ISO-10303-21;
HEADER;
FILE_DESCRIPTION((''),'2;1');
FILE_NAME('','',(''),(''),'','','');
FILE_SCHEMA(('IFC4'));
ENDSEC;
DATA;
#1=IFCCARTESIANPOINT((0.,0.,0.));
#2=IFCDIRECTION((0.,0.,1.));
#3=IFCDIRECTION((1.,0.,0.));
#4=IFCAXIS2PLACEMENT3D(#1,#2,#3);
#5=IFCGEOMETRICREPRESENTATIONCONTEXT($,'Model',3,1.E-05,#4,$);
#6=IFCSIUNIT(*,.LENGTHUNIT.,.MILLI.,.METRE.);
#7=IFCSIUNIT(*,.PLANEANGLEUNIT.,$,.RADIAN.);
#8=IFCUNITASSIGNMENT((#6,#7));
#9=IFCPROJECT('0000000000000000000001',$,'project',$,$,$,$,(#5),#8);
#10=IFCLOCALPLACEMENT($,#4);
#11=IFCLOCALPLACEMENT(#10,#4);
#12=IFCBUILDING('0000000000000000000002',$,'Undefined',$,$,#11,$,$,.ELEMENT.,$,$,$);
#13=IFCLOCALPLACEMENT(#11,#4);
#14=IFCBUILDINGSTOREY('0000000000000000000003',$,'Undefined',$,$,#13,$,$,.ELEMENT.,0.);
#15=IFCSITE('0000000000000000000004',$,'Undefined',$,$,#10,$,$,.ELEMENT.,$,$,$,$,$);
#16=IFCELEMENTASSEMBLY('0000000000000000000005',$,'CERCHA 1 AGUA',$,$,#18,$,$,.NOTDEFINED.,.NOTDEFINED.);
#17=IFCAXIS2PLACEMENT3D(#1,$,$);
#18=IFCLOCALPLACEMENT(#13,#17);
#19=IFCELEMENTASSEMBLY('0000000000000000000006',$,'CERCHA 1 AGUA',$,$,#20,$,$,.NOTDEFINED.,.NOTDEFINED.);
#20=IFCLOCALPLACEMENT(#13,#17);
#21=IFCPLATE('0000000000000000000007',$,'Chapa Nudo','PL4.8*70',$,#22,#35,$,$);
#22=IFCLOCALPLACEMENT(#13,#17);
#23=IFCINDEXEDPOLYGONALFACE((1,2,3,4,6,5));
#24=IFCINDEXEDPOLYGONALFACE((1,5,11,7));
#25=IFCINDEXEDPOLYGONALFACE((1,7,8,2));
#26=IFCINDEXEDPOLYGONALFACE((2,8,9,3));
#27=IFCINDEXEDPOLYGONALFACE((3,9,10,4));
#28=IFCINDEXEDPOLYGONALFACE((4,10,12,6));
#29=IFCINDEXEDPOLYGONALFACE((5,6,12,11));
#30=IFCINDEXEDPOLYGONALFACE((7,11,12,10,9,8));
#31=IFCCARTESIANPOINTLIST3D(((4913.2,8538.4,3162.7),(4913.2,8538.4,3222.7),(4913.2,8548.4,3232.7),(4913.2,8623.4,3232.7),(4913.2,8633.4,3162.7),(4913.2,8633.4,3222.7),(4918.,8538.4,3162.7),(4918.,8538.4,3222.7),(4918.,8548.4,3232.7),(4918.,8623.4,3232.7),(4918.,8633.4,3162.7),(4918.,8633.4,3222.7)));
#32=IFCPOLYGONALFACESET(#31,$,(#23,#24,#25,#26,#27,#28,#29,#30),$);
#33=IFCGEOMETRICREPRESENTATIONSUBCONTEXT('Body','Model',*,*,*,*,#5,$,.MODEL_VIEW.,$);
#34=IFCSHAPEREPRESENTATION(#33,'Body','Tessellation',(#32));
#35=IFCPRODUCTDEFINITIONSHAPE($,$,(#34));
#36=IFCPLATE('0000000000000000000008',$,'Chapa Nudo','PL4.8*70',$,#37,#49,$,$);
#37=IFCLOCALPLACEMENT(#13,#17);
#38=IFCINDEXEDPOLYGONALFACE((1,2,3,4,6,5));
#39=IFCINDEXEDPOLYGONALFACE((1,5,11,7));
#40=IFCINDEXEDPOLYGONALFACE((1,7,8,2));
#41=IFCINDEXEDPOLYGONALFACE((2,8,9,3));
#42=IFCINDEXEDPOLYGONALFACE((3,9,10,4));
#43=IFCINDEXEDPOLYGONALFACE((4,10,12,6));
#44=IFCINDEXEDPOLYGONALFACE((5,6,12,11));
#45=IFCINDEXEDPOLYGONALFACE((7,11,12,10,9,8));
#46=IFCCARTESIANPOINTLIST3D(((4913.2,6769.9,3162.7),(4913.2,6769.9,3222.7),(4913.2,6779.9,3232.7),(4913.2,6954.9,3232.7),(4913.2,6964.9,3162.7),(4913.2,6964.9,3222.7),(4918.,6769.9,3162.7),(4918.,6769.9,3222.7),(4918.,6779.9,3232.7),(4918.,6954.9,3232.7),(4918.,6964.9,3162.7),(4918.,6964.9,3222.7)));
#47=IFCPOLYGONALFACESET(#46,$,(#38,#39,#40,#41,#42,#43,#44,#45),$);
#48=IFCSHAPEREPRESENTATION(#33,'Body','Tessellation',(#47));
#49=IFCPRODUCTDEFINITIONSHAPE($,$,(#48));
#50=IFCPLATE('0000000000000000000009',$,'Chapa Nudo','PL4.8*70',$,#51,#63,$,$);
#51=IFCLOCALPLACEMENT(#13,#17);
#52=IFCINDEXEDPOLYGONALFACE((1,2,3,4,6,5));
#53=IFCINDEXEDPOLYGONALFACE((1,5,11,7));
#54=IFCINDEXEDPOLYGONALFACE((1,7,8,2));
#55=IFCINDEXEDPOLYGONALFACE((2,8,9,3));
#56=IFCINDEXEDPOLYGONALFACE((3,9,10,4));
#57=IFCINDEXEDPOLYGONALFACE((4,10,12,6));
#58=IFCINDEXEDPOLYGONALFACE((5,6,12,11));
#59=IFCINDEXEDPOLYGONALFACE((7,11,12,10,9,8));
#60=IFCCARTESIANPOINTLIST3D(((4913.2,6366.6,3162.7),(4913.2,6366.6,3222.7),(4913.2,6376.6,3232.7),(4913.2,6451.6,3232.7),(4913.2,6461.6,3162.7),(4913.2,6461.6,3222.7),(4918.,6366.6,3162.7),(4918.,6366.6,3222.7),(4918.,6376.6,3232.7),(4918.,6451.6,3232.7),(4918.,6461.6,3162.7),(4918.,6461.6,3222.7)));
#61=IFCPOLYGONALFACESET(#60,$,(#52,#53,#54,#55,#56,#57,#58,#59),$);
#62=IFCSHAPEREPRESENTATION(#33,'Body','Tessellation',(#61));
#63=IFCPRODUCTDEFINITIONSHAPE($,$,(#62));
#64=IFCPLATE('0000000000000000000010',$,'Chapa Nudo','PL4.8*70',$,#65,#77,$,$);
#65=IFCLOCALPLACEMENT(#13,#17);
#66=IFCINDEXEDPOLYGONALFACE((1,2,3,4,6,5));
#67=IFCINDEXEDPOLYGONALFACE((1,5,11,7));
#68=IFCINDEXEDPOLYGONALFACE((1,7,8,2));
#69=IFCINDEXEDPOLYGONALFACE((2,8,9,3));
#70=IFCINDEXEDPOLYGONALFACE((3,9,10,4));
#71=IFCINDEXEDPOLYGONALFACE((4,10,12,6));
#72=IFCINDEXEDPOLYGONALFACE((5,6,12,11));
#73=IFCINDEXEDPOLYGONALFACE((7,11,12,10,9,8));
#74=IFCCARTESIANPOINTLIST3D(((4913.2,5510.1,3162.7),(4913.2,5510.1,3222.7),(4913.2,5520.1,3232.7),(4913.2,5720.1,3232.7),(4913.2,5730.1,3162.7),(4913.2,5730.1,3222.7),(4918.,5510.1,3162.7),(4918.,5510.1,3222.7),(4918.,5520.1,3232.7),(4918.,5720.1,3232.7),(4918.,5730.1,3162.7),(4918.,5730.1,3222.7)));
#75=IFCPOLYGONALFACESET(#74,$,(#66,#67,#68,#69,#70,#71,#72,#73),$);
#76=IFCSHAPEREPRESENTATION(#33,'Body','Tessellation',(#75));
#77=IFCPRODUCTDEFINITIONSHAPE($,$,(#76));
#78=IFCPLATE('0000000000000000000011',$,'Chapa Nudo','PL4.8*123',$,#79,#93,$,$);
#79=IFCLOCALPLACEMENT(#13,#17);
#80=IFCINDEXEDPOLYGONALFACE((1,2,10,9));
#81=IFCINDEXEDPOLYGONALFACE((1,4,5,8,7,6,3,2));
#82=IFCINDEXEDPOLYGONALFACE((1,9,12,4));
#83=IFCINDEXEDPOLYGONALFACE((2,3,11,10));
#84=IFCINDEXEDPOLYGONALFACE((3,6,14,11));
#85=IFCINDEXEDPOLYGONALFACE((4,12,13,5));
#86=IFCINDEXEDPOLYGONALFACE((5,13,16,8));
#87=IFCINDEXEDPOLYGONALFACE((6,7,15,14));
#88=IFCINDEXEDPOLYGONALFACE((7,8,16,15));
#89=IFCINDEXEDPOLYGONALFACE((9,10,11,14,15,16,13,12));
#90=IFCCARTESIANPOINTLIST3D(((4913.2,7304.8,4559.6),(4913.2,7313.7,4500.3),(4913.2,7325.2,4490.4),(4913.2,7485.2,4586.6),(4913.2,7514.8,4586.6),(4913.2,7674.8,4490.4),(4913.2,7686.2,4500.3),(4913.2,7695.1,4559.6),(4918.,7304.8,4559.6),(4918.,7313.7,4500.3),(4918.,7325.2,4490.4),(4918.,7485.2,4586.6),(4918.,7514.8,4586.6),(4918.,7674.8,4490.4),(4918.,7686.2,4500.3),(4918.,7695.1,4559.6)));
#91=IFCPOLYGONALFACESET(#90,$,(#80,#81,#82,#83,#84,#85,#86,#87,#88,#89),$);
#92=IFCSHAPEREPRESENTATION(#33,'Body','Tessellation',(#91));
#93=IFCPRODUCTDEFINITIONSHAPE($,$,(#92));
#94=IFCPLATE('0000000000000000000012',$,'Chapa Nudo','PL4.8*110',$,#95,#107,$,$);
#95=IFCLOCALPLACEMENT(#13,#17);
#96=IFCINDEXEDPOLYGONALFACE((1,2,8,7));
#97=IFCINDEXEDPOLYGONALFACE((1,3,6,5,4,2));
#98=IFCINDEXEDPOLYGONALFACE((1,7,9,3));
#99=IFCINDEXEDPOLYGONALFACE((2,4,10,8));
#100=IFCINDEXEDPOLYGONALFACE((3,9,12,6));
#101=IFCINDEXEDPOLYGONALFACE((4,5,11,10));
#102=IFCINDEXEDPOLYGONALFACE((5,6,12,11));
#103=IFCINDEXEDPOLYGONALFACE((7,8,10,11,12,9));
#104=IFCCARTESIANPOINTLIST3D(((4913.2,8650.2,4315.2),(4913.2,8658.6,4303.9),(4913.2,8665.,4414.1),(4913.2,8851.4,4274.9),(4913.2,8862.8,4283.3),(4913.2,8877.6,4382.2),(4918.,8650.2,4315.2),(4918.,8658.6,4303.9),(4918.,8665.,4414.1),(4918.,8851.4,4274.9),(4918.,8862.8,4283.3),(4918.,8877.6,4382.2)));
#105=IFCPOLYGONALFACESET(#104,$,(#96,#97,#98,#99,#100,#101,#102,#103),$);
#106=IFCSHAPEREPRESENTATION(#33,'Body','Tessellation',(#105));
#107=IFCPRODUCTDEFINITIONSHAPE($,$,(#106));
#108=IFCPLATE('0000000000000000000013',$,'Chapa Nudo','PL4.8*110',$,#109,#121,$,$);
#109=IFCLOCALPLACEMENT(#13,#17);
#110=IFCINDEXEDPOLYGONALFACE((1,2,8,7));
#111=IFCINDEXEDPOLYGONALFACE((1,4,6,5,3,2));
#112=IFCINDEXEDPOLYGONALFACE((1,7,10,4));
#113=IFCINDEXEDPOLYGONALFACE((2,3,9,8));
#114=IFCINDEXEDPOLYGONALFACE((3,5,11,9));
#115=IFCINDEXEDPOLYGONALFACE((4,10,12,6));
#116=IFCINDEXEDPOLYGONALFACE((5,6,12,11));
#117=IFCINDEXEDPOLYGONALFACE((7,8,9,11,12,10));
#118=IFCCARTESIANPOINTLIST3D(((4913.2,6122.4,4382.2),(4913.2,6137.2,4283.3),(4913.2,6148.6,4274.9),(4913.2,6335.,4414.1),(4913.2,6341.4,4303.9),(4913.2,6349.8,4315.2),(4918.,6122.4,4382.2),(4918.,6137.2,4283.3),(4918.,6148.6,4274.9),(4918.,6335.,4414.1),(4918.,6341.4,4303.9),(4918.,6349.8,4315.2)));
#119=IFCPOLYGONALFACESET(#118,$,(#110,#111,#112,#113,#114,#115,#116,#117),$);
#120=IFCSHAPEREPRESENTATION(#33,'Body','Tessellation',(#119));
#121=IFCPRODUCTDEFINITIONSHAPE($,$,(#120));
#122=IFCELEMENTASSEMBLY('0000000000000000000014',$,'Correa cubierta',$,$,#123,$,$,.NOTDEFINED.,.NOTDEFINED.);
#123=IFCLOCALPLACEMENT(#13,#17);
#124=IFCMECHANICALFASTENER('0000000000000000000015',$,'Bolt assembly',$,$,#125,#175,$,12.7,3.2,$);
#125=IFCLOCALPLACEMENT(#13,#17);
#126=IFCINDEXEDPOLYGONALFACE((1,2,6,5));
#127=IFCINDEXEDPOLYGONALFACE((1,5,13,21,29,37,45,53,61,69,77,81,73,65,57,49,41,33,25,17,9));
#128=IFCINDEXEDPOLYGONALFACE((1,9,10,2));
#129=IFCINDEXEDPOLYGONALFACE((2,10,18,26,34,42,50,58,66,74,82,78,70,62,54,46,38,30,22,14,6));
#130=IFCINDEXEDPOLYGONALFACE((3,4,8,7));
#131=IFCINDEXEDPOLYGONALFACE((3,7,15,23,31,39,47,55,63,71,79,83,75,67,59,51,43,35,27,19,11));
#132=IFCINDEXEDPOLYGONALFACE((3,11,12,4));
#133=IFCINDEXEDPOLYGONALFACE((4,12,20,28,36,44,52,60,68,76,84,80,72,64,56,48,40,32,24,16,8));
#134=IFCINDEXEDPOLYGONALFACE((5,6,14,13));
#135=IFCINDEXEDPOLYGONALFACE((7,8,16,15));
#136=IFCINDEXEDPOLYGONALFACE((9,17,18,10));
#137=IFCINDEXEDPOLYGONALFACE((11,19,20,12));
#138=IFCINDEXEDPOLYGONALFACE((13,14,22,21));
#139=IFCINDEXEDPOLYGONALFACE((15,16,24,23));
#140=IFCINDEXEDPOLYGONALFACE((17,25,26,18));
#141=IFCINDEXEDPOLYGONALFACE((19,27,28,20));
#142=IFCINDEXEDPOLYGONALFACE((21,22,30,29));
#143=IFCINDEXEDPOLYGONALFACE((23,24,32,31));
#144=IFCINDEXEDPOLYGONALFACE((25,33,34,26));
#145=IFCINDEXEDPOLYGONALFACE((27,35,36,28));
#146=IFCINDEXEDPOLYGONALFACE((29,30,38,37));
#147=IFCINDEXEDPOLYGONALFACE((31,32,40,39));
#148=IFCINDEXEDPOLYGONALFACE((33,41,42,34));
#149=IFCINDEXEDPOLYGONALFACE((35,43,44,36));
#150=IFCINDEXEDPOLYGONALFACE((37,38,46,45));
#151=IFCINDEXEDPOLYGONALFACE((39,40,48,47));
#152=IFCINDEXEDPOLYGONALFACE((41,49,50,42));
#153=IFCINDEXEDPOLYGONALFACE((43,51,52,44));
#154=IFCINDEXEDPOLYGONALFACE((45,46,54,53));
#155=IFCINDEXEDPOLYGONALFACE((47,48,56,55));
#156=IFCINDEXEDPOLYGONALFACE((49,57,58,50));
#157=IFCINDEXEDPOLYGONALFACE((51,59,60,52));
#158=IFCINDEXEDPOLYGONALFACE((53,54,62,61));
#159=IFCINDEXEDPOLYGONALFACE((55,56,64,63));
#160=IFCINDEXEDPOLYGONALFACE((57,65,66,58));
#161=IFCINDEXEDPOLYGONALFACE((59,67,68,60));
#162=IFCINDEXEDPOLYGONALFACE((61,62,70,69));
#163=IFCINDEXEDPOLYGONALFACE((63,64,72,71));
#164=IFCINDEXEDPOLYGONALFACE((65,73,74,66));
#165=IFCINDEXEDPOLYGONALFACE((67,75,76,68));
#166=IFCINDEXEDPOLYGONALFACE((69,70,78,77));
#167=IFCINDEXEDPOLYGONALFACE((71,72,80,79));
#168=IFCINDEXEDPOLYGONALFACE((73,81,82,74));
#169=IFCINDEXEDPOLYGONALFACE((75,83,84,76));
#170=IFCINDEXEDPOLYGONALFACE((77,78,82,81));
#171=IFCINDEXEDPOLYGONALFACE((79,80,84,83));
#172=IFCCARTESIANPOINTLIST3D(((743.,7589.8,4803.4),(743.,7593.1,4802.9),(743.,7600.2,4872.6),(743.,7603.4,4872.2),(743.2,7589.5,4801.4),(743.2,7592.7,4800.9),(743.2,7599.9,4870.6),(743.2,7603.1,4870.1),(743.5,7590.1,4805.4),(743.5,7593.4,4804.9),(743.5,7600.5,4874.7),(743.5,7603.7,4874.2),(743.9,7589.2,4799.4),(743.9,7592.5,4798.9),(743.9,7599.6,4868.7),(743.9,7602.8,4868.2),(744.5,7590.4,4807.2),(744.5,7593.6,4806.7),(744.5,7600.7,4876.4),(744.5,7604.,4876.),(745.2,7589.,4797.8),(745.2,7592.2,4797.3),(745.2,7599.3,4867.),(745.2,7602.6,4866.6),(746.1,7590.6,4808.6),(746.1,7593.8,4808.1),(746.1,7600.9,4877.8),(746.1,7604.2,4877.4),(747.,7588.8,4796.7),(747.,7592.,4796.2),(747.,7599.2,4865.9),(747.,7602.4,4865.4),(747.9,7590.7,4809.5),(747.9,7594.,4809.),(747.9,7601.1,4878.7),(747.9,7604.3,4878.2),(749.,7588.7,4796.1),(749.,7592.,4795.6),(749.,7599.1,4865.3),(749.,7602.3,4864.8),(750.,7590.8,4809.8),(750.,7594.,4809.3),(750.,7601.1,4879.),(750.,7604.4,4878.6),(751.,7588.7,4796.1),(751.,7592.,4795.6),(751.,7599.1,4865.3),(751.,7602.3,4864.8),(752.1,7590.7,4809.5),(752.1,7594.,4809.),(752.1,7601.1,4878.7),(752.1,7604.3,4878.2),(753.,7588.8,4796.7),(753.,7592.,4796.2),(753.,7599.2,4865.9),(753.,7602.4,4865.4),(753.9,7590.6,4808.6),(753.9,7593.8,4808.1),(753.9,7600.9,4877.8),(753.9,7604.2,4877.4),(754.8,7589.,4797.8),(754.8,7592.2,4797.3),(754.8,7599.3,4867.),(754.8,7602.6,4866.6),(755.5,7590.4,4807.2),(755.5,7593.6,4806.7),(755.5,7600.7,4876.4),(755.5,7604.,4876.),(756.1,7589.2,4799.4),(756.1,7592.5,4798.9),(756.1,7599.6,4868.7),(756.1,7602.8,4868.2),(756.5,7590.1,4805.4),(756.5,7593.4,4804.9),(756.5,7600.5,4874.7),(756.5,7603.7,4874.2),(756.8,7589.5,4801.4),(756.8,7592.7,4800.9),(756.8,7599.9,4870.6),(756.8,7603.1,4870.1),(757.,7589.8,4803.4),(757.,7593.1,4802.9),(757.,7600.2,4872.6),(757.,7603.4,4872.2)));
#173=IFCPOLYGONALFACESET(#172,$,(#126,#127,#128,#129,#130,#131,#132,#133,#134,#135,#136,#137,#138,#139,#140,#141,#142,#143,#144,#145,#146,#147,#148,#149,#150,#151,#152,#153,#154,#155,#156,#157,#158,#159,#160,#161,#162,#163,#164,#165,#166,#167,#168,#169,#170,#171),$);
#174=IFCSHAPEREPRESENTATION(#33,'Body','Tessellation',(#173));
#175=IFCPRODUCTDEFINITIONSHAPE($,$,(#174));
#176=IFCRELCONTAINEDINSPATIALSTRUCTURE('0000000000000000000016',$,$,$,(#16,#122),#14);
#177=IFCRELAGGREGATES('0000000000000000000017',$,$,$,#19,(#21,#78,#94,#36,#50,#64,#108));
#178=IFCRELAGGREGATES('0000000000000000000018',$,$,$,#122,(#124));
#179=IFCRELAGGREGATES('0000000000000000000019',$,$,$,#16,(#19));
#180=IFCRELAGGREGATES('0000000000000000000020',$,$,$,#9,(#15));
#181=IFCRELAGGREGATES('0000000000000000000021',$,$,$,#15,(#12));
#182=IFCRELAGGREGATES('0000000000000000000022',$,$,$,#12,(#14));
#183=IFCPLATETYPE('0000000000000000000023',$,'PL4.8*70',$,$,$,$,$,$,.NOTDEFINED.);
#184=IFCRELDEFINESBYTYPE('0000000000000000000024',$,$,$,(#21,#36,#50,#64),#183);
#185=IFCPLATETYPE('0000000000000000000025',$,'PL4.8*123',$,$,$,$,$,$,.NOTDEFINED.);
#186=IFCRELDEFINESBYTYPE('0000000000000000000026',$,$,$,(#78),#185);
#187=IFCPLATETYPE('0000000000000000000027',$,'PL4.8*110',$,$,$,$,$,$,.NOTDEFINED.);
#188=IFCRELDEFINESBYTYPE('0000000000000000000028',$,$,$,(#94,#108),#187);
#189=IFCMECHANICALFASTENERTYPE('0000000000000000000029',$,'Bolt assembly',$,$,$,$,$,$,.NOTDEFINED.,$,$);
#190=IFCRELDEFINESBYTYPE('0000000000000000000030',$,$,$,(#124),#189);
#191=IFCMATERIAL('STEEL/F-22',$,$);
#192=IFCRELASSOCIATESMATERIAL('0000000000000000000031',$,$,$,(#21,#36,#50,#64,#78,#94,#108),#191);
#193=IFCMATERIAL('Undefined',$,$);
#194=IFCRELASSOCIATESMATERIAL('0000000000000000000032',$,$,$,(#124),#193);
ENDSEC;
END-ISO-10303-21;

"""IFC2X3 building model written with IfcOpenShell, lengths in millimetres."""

from ifc_helpers import new_model, si_unit, frame, origin_with_axes, origin_2d_with_axis, place, context, subcontext, project, spatial, polyline, circle, outline, extrude, source, transform, mapped, material, type_object, element, aggregate, save


model = new_model("IFC2X3")

# Units and contexts
model_context = context("Model", 3, precision=1e-05, world=origin_with_axes())
body_context = subcontext(model_context, "Body", "Model", "MODEL_VIEW")
ifc_project = project(units=[si_unit("LENGTHUNIT", "METRE", prefix="MILLI"), si_unit("PLANEANGLEUNIT", "RADIAN")], contexts=[model_context])

# Site, building, storey
site_placement = place(None, origin_with_axes())
site = spatial("IfcSite", under=ifc_project, at=site_placement, Name="Undefined", CompositionType="ELEMENT")
building_placement = place(site_placement, origin_with_axes())
building = spatial("IfcBuilding", under=site, at=building_placement, Name="Undefined", CompositionType="ELEMENT")
storey_placement = place(building_placement, origin_with_axes())
storey = spatial("IfcBuildingStorey", under=building, at=storey_placement, Name="Undefined", CompositionType="ELEMENT", Elevation=0.0)

# Element assembly
assembly_1_placement = place(storey_placement, origin_with_axes())
assembly_1 = element("IfcElementAssembly", 1, at=assembly_1_placement, inside=storey, Name="CERCHA 1 AGUA", AssemblyPlace="NOTDEFINED", PredefinedType="NOTDEFINED")

# Element assembly, plates
assembly_2_placement = place(assembly_1_placement, origin_with_axes())
assembly_2 = element("IfcElementAssembly", 2, at=assembly_2_placement, Name="CERCHA 1 AGUA", AssemblyPlace="NOTDEFINED", PredefinedType="NOTDEFINED")
ifc_material_1 = material(Name="STEEL/F-22")
plate_type_1 = type_object("IfcPlateType", Name="PL4.8*70", PredefinedType="NOTDEFINED")
plate_1_placement = place(assembly_2_placement, frame((4915.6, 8633.4, 3232.7), z_axis=(-1.0, 0.0, 0.0), x_axis=(0.0, 0.0, -1.0)))
plate_1 = element("IfcPlate", 3, at=plate_1_placement, type_object=plate_type_1, material=ifc_material_1, Name="Chapa Nudo", Description="PL4.8*70", context=body_context, shape_type="SweptSolid", body=[
    extrude(outline(polyline([(0.0, 10.0), (10.0, 0.0), (70.0, 0.0), (70.0, 95.0), (10.0, 95.0), (0.0, 85.0), (0.0, 10.0)])), frame((0.0, 0.0, -2.4), z_axis=(0.0, 0.0, 1.0), x_axis=(1.0, 0.0, 0.0)), (0.0, 0.0, 1.0), 4.8),
])
plate_2_placement = place(assembly_2_placement, frame((4915.6, 6769.9, 3232.7), z_axis=(1.0, 0.0, 0.0), x_axis=(0.0, 0.0, -1.0)))
plate_2 = element("IfcPlate", 4, at=plate_2_placement, type_object=plate_type_1, material=ifc_material_1, Name="Chapa Nudo", Description="PL4.8*70", context=body_context, shape_type="SweptSolid", body=[
    extrude(outline(polyline([(0.0, 10.0), (10.0, 0.0), (70.0, 0.0), (70.0, 195.0), (10.0, 195.0), (0.0, 185.0), (0.0, 10.0)])), frame((0.0, 0.0, -2.4), z_axis=(0.0, 0.0, 1.0), x_axis=(1.0, 0.0, 0.0)), (0.0, 0.0, 1.0), 4.8),
])
plate_3_placement = place(assembly_2_placement, frame((4915.6, 6366.6, 3232.7), z_axis=(1.0, 0.0, 0.0), x_axis=(0.0, 0.0, -1.0)))
plate_3 = element("IfcPlate", 5, at=plate_3_placement, type_object=plate_type_1, material=ifc_material_1, Name="Chapa Nudo", Description="PL4.8*70", context=body_context, shape_type="SweptSolid", body=[
    extrude(outline(polyline([(0.0, 10.0), (10.0, 0.0), (70.0, 0.0), (70.0, 95.0), (10.0, 95.0), (0.0, 85.0), (0.0, 10.0)])), frame((0.0, 0.0, -2.4), z_axis=(0.0, 0.0, 1.0), x_axis=(1.0, 0.0, 0.0)), (0.0, 0.0, 1.0), 4.8),
])
plate_4_placement = place(assembly_2_placement, frame((4915.6, 5510.1, 3232.7), z_axis=(1.0, 0.0, 0.0), x_axis=(0.0, 0.0, -1.0)))
plate_4 = element("IfcPlate", 6, at=plate_4_placement, type_object=plate_type_1, material=ifc_material_1, Name="Chapa Nudo", Description="PL4.8*70", context=body_context, shape_type="SweptSolid", body=[
    extrude(outline(polyline([(0.0, 10.0), (10.0, 0.0), (70.0, 0.0), (70.0, 220.0), (10.0, 220.0), (0.0, 210.0), (0.0, 10.0)])), frame((0.0, 0.0, -2.4), z_axis=(0.0, 0.0, 1.0), x_axis=(1.0, 0.0, 0.0)), (0.0, 0.0, 1.0), 4.8),
])
plate_type_2 = type_object("IfcPlateType", Name="PL4.8*123", PredefinedType="NOTDEFINED")
plate_5_placement = place(assembly_2_placement, frame((4915.6, 7695.1, 4559.6), z_axis=(-1.0, 0.0, 0.0), x_axis=(0.0, -0.148335, -0.988937)))
plate_5 = element("IfcPlate", 7, at=plate_5_placement, type_object=plate_type_2, material=ifc_material_1, Name="Chapa Nudo", Description="PL4.8*123", context=body_context, shape_type="SweptSolid", body=[
    extrude(outline(polyline([(0.0, 0.0), (60.0, 0.0), (71.5, 9.9), (123.3, 355.6), (115.3, 368.4), (57.9, 386.0), (4.4, 211.7), (0.0, 182.3), (0.0, 0.0)])), frame((0.0, 0.0, -2.4), z_axis=(0.0, 0.0, 1.0), x_axis=(1.0, 0.0, 0.0)), (0.0, 0.0, 1.0), 4.8),
])
plate_type_3 = type_object("IfcPlateType", Name="PL4.8*110", PredefinedType="NOTDEFINED")
plate_6_placement = place(assembly_2_placement, frame((4915.6, 8877.6, 4382.2), z_axis=(-1.0, 0.0, 0.0), x_axis=(0.0, -0.148335, -0.988937)))
plate_6 = element("IfcPlate", 8, at=plate_6_placement, type_object=plate_type_3, material=ifc_material_1, Name="Chapa Nudo", Description="PL4.8*110", context=body_context, shape_type="SweptSolid", body=[
    extrude(outline(polyline([(0.0, 0.0), (100.0, 0.0), (110.0, 10.0), (110.0, 205.0), (100.0, 215.0), (0.0, 215.0), (0.0, 0.0)])), frame((0.0, 0.0, -2.4), z_axis=(0.0, 0.0, 1.0), x_axis=(1.0, 0.0, 0.0)), (0.0, 0.0, 1.0), 4.8),
])
plate_7_placement = place(assembly_2_placement, frame((4915.6, 6122.4, 4382.2), z_axis=(1.0, 0.0, 0.0), x_axis=(0.0, 0.148335, -0.988937)))
plate_7 = element("IfcPlate", 9, at=plate_7_placement, type_object=plate_type_3, material=ifc_material_1, Name="Chapa Nudo", Description="PL4.8*110", context=body_context, shape_type="SweptSolid", body=[
    extrude(outline(polyline([(0.0, 0.0), (100.0, 0.0), (110.0, 10.0), (110.0, 205.0), (100.0, 215.0), (0.0, 215.0), (0.0, 0.0)])), frame((0.0, 0.0, -2.4), z_axis=(0.0, 0.0, 1.0), x_axis=(1.0, 0.0, 0.0)), (0.0, 0.0, 1.0), 4.8),
])
aggregate(assembly_2, [plate_1, plate_5, plate_6, plate_2, plate_3, plate_4, plate_7])

# Shared definitions
ifc_material_2 = material(Name="Undefined")
mechanical_fastener_type = type_object("IfcMechanicalFastenerType", Name="Bolt assembly")

# Element assembly, mechanical fastener
assembly_3_placement = place(storey_placement, origin_with_axes())
assembly_3 = element("IfcElementAssembly", 10, at=assembly_3_placement, inside=storey, Name="Correa cubierta", AssemblyPlace="NOTDEFINED", PredefinedType="NOTDEFINED")
shared_shape_1 = source(origin_with_axes(), body_context, "Body", "SweptSolid", [
    extrude(circle(Radius=7.0, at=origin_2d_with_axis()), frame((0.0, 3.2, 0.0), z_axis=(0.0, 1.0, 0.0), x_axis=(1.0, 0.0, 0.0)), (0.0, 0.0, 1.0), 3.3),
])
mechanical_fastener_1_placement = place(assembly_3_placement, frame((750.0, 7586.6, 4803.4), z_axis=(-1.0, 0.0, 0.0), x_axis=(0.0, 0.148209, 0.988956)))
mechanical_fastener_1 = element("IfcMechanicalFastener", 11, at=mechanical_fastener_1_placement, type_object=mechanical_fastener_type, material=ifc_material_2, Name="Bolt assembly", NominalDiameter=12.7, NominalLength=3.2, context=body_context, shape_type="MappedRepresentation", body=[
    mapped(shared_shape_1, transform((0.0, 0.0, 0.0))),
    mapped(shared_shape_1, transform((70.0, 0.0, 0.0))),
])
aggregate(assembly_3, [mechanical_fastener_1])

aggregate(assembly_1, [assembly_2])

save(model, "model.ifc")
